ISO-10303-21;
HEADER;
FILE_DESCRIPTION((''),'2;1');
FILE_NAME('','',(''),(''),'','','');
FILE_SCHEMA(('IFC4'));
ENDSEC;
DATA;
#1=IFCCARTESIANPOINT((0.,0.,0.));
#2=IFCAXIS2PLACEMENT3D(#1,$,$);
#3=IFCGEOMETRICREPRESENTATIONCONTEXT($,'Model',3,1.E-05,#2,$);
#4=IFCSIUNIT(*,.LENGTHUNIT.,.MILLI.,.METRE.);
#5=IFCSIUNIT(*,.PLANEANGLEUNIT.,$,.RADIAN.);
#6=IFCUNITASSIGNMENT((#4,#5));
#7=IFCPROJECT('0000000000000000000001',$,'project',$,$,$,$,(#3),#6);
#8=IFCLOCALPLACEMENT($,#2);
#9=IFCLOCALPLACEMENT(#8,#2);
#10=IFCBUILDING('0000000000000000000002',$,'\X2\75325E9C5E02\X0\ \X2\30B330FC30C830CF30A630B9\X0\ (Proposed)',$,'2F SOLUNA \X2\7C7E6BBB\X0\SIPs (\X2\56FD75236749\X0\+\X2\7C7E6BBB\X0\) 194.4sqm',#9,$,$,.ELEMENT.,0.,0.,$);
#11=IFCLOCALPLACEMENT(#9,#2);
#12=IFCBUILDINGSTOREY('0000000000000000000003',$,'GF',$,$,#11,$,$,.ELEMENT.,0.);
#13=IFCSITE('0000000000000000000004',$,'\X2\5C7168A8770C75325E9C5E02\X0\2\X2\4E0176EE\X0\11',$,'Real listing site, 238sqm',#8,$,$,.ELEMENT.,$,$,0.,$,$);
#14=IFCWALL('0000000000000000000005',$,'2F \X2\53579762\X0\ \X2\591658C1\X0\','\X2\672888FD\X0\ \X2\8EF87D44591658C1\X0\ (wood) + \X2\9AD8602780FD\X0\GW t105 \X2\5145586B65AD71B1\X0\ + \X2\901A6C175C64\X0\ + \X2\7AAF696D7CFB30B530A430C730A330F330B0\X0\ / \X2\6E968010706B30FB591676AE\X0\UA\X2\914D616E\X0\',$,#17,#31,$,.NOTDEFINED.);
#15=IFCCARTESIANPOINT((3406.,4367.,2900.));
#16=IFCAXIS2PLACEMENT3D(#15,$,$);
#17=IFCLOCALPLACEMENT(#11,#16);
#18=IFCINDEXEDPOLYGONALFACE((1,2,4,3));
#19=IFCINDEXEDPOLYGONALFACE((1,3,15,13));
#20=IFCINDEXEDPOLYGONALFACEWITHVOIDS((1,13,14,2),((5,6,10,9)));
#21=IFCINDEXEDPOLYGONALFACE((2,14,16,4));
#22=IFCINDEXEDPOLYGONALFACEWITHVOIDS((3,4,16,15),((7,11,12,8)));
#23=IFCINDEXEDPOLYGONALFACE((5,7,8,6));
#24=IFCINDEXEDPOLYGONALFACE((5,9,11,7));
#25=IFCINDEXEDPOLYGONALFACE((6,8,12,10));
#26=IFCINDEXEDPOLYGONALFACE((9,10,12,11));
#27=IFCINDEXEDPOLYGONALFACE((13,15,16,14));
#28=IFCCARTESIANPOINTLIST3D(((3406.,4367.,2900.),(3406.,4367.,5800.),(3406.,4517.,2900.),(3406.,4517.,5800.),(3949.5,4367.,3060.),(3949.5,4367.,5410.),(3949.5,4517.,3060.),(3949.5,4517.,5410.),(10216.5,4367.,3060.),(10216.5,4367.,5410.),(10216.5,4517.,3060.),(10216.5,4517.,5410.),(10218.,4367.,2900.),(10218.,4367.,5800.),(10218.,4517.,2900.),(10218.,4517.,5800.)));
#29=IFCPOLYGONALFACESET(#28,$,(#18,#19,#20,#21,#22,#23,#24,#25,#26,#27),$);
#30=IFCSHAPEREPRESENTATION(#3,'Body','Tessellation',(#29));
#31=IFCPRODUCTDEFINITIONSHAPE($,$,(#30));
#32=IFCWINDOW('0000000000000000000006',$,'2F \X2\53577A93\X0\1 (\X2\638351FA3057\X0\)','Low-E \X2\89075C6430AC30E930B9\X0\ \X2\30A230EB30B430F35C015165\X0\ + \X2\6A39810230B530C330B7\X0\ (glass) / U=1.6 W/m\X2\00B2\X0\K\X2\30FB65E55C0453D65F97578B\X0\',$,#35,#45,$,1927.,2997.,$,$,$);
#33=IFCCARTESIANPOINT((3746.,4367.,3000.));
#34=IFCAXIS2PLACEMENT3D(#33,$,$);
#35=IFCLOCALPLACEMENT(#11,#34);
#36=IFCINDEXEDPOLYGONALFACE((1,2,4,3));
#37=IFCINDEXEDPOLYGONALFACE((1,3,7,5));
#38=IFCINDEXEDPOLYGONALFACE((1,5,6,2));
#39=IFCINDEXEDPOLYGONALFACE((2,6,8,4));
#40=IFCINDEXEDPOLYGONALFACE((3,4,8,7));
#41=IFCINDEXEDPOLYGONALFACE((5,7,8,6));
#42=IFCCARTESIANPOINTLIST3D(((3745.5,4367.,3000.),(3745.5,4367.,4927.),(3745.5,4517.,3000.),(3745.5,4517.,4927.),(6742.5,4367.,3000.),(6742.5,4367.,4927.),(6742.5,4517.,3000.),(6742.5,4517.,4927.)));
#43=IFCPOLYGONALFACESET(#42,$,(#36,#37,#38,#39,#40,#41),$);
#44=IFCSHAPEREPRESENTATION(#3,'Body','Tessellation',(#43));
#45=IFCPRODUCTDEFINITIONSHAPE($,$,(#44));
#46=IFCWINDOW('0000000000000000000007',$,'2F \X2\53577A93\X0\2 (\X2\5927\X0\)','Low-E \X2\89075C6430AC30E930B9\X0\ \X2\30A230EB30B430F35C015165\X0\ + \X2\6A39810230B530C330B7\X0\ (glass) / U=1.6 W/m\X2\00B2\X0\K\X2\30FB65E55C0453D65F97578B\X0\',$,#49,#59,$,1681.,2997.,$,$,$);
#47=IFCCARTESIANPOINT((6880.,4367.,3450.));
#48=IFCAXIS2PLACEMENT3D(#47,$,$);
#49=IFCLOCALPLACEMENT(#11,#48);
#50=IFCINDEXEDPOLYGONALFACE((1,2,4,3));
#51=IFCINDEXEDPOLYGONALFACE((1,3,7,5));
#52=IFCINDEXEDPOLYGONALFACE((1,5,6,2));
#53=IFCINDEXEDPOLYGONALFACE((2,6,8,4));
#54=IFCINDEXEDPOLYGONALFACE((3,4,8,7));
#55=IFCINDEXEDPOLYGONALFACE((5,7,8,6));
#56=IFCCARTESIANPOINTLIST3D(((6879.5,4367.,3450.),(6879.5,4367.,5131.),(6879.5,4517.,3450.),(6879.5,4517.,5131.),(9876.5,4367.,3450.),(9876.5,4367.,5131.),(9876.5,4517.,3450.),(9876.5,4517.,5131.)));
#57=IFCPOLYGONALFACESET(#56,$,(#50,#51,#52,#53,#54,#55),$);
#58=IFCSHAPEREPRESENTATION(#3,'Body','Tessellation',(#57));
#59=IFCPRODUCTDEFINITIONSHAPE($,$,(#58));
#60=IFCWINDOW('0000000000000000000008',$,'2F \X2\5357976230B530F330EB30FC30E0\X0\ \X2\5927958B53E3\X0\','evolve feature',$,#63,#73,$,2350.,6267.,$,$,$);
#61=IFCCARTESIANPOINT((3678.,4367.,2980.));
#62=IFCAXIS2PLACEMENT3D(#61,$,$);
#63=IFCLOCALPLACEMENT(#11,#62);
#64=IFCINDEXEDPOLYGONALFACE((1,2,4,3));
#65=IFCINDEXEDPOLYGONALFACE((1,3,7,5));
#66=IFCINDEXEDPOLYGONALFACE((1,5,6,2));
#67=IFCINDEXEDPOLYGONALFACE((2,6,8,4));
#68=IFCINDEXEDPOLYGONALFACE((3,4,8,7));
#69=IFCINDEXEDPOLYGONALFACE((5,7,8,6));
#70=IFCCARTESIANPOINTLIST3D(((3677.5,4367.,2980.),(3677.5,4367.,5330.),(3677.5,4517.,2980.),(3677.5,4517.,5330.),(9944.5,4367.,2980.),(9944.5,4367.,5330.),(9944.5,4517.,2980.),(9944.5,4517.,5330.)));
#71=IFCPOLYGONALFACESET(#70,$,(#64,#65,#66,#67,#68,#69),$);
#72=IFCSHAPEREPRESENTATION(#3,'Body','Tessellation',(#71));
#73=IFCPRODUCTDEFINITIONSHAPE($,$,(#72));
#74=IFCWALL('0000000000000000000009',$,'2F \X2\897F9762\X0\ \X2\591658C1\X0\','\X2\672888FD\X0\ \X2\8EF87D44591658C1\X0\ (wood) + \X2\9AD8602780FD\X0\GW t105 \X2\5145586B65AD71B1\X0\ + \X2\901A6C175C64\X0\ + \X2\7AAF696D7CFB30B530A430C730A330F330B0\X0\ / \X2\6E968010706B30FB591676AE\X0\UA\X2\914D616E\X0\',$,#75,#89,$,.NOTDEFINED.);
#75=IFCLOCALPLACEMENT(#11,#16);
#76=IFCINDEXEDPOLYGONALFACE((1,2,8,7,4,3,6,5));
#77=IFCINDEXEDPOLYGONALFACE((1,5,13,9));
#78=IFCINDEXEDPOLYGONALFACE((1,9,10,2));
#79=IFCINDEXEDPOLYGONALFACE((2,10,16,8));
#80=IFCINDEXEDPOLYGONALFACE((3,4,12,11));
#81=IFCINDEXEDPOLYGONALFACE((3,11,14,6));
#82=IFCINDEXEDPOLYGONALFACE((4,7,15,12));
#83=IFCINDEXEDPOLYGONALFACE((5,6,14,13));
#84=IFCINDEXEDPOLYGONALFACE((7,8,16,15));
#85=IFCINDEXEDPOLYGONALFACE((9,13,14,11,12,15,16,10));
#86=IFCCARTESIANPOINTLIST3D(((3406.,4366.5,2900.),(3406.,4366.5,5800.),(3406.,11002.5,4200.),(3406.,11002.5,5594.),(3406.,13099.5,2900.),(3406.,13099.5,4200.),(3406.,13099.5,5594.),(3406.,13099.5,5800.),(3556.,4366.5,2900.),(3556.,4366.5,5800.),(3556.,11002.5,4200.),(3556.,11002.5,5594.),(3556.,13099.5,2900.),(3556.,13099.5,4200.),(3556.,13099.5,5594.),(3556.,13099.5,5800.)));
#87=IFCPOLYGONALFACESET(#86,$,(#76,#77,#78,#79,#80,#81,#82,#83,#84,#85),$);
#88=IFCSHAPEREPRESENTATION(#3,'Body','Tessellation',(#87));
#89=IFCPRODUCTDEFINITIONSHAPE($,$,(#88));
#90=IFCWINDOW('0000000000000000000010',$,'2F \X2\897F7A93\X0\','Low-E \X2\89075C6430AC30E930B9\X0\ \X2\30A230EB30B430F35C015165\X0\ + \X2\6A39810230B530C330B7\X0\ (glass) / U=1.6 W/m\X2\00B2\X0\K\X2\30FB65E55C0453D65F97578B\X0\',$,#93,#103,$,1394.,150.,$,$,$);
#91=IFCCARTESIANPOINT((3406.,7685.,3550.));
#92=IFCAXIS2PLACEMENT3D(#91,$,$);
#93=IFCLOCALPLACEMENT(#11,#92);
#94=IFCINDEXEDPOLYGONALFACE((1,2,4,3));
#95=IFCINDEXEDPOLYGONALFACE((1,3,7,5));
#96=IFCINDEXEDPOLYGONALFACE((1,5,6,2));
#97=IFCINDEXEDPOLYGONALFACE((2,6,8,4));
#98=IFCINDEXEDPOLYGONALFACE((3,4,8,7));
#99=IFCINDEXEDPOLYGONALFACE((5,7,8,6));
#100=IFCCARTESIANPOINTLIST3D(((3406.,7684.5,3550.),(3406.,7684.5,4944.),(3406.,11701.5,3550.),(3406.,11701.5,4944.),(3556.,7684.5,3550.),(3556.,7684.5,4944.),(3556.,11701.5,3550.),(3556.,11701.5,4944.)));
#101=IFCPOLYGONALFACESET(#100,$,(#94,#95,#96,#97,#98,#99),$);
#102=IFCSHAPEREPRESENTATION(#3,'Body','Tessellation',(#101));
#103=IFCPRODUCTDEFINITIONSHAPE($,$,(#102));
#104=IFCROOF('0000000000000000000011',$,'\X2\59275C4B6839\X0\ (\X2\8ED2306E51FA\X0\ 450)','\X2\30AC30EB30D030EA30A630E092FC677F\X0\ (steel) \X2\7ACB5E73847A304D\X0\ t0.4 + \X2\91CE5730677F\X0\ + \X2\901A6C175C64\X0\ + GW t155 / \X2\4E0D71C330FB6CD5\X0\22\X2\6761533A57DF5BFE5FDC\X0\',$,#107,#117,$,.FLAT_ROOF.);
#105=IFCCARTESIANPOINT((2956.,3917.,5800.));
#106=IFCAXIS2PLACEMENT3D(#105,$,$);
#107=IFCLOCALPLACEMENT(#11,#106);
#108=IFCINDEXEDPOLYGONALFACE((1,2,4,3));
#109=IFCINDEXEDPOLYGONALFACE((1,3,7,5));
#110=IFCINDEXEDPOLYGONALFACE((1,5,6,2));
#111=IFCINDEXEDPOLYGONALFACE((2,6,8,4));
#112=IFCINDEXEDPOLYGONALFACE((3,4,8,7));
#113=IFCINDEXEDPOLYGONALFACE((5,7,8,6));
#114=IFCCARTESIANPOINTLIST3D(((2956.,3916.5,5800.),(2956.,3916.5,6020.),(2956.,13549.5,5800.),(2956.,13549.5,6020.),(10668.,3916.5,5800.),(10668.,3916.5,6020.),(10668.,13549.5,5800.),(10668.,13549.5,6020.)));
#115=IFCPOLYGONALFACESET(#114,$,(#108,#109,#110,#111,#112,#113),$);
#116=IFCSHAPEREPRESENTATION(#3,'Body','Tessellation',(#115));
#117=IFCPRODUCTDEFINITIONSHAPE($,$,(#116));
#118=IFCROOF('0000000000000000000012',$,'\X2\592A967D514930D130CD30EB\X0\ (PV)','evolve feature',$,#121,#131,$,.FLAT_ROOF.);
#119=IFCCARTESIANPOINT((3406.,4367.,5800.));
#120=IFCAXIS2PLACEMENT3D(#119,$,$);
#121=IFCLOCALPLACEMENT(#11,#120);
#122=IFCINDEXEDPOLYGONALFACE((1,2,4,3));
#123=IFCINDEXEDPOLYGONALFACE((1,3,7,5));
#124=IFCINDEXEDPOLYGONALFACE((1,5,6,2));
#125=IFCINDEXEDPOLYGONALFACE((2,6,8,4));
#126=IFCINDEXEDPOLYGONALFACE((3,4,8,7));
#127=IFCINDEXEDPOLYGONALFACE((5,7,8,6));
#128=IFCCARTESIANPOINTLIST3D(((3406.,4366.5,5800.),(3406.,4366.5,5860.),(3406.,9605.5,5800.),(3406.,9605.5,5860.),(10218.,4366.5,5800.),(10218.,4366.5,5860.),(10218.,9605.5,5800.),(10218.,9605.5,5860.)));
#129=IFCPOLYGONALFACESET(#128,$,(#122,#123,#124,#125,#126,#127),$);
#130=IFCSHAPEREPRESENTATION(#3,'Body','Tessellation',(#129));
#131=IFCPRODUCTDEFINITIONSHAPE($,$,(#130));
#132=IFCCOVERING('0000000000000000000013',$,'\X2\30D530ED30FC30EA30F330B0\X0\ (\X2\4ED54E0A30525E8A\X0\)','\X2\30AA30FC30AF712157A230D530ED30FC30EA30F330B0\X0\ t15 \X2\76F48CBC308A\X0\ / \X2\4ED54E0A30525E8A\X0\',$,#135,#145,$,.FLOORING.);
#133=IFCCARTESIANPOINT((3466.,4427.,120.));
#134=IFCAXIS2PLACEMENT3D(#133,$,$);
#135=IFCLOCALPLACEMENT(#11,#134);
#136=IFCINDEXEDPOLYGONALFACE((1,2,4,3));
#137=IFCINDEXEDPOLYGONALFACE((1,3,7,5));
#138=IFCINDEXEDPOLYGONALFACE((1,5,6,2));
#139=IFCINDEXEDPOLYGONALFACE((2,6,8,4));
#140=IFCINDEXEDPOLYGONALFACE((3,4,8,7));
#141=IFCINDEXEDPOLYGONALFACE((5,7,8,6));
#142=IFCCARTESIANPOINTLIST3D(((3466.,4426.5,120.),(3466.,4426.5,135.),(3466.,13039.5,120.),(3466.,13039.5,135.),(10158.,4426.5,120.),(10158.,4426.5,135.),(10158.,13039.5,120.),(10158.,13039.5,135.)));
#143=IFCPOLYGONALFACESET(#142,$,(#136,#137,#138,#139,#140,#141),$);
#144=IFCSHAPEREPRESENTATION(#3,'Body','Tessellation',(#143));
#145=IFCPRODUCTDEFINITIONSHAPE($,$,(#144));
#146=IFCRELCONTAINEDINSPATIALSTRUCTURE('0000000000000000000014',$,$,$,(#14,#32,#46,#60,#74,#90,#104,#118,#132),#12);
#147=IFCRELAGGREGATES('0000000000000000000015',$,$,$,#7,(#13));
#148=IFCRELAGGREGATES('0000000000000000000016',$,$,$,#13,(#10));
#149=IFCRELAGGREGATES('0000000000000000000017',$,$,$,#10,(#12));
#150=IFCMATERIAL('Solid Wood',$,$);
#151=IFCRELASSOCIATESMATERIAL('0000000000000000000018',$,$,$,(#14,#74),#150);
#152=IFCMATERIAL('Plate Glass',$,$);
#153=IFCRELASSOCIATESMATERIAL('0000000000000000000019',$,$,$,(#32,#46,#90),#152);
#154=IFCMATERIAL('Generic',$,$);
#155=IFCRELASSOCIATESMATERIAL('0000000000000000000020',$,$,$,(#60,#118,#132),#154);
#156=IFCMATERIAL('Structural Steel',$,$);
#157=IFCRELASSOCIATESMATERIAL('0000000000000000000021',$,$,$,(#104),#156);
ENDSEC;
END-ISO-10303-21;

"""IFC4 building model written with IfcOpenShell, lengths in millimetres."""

from ifc_helpers import new_model, si_unit, frame, frame_2d, origin, place, context, project, spatial, rectangle, extrude, material, element, fill, save


model = new_model("IFC4")

# Units and contexts
model_context = context("Model", 3, precision=1e-05, world=origin())
ifc_project = project(units=[si_unit("LENGTHUNIT", "METRE", prefix="MILLI"), si_unit("PLANEANGLEUNIT", "RADIAN")], contexts=[model_context])

# Site, building, storey
site_placement = place(None, origin())
site = spatial("IfcSite", under=ifc_project, at=site_placement, Name="山梨県甲府市2丁目11", ObjectType="Real listing site, 238sqm", CompositionType="ELEMENT", RefElevation=0.0)
building_placement = place(site_placement, origin())
building = spatial("IfcBuilding", under=site, at=building_placement, Name="甲府市 コートハウス (Proposed)", ObjectType="2F SOLUNA 籾殻SIPs (国産杉+籾殻) 194.4sqm", CompositionType="ELEMENT", ElevationOfRefHeight=0.0, ElevationOfTerrain=0.0)
storey_placement = place(building_placement, origin())
storey = spatial("IfcBuildingStorey", under=building, at=storey_placement, Name="GF", CompositionType="ELEMENT", Elevation=0.0)

# Shared definitions
ifc_material_1 = material(Name="Solid Wood")

# Shared definitions
ifc_material_2 = material(Name="Plate Glass")
ifc_material_3 = material(Name="Generic")

# Wall, openings, windows
wall_1_placement = place(storey_placement, frame((3406.0, 4367.0, 2900.0)))
wall_1 = element("IfcWall", 1, at=wall_1_placement, inside=storey, material=ifc_material_1, Name="2F 南面 外壁", Description="木製 軸組外壁 (wood) + 高性能GW t105 充填断熱 + 通気層 + 窯業系サイディング / 準耐火・外皮UA配慮", PredefinedType="NOTDEFINED", context=model_context, shape_type="SweptSolid", body=[
    extrude(rectangle(XDim=6812.0, YDim=150.0, at=frame_2d((3406.0, 75.0))), frame((3406.0, 4367.0, 2900.0)), (0.0, 0.0, 1.0), 2900.0),
])
opening_1_placement = place(storey_placement, frame((3746.0, 4367.0, 3000.0)))
opening_1 = element("IfcOpeningElement", 2, at=opening_1_placement, cuts=wall_1, PredefinedType="NOTDEFINED", context=model_context, shape_type="SweptSolid", body=[
    extrude(rectangle(XDim=2997.0, YDim=150.0, at=frame_2d((1498.0, 75.0))), frame((3746.0, 4367.0, 3000.0)), (0.0, 0.0, 1.0), 1927.0),
])
opening_2_placement = place(storey_placement, frame((6880.0, 4367.0, 3450.0)))
opening_2 = element("IfcOpeningElement", 3, at=opening_2_placement, cuts=wall_1, PredefinedType="NOTDEFINED", context=model_context, shape_type="SweptSolid", body=[
    extrude(rectangle(XDim=2997.0, YDim=150.0, at=frame_2d((1498.0, 75.0))), frame((6880.0, 4367.0, 3450.0)), (0.0, 0.0, 1.0), 1681.0),
])
opening_3_placement = place(storey_placement, frame((3678.0, 4367.0, 2980.0)))
opening_3 = element("IfcOpeningElement", 4, at=opening_3_placement, cuts=wall_1, PredefinedType="NOTDEFINED", context=model_context, shape_type="SweptSolid", body=[
    extrude(rectangle(XDim=6267.0, YDim=150.0, at=frame_2d((3133.0, 75.0))), frame((3678.0, 4367.0, 2980.0)), (0.0, 0.0, 1.0), 2350.0),
])
window_1_placement = place(storey_placement, frame((3746.0, 4367.0, 3000.0)))
window_1 = element("IfcWindow", 5, at=window_1_placement, inside=storey, material=ifc_material_2, Name="2F 南窓1 (掃出し)", Description="Low-E 複層ガラス アルゴン封入 + 樹脂サッシ (glass) / U=1.6 W/m²K・日射取得型", OverallHeight=1927.0, OverallWidth=2997.0, context=model_context, shape_type="SweptSolid", body=[
    extrude(rectangle(XDim=2997.0, YDim=150.0, at=frame_2d((1498.0, 75.0))), frame((3746.0, 4367.0, 3000.0)), (0.0, 0.0, 1.0), 1927.0),
])
fill(opening_1, window_1)
window_2_placement = place(storey_placement, frame((6880.0, 4367.0, 3450.0)))
window_2 = element("IfcWindow", 6, at=window_2_placement, inside=storey, material=ifc_material_2, Name="2F 南窓2 (大)", Description="Low-E 複層ガラス アルゴン封入 + 樹脂サッシ (glass) / U=1.6 W/m²K・日射取得型", OverallHeight=1681.0, OverallWidth=2997.0, context=model_context, shape_type="SweptSolid", body=[
    extrude(rectangle(XDim=2997.0, YDim=150.0, at=frame_2d((1498.0, 75.0))), frame((6880.0, 4367.0, 3450.0)), (0.0, 0.0, 1.0), 1681.0),
])
fill(opening_2, window_2)
window_3_placement = place(storey_placement, frame((3678.0, 4367.0, 2980.0)))
window_3 = element("IfcWindow", 7, at=window_3_placement, inside=storey, material=ifc_material_3, Name="2F 南面サンルーム 大開口", Description="evolve feature", OverallHeight=2350.0, OverallWidth=6267.0, context=model_context, shape_type="SweptSolid", body=[
    extrude(rectangle(XDim=6267.0, YDim=150.0, at=frame_2d((3133.0, 75.0))), frame((3678.0, 4367.0, 2980.0)), (0.0, 0.0, 1.0), 2350.0),
])
fill(opening_3, window_3)

# Wall, opening, window
wall_2_placement = place(storey_placement, frame((3406.0, 4367.0, 2900.0)))
wall_2 = element("IfcWall", 8, at=wall_2_placement, inside=storey, material=ifc_material_1, Name="2F 西面 外壁", Description="木製 軸組外壁 (wood) + 高性能GW t105 充填断熱 + 通気層 + 窯業系サイディング / 準耐火・外皮UA配慮", PredefinedType="NOTDEFINED", context=model_context, shape_type="SweptSolid", body=[
    extrude(rectangle(XDim=150.0, YDim=8733.0, at=frame_2d((75.0, 4366.0))), frame((3406.0, 4367.0, 2900.0)), (0.0, 0.0, 1.0), 2900.0),
])
opening_4_placement = place(storey_placement, frame((3406.0, 7685.0, 3550.0)))
opening_4 = element("IfcOpeningElement", 9, at=opening_4_placement, cuts=wall_2, PredefinedType="NOTDEFINED", context=model_context, shape_type="SweptSolid", body=[
    extrude(rectangle(XDim=150.0, YDim=4017.0, at=frame_2d((75.0, 2008.0))), frame((3406.0, 7685.0, 3550.0)), (0.0, 0.0, 1.0), 1394.0),
])
window_4_placement = place(storey_placement, frame((3406.0, 7685.0, 3550.0)))
window_4 = element("IfcWindow", 10, at=window_4_placement, inside=storey, material=ifc_material_2, Name="2F 西窓", Description="Low-E 複層ガラス アルゴン封入 + 樹脂サッシ (glass) / U=1.6 W/m²K・日射取得型", OverallHeight=1394.0, OverallWidth=150.0, context=model_context, shape_type="SweptSolid", body=[
    extrude(rectangle(XDim=150.0, YDim=4017.0, at=frame_2d((75.0, 2008.0))), frame((3406.0, 7685.0, 3550.0)), (0.0, 0.0, 1.0), 1394.0),
])
fill(opening_4, window_4)

# Roofs
ifc_material_4 = material(Name="Structural Steel")
roof_1_placement = place(storey_placement, frame((2956.0, 3917.0, 5800.0)))
element("IfcRoof", 11, at=roof_1_placement, inside=storey, material=ifc_material_4, Name="大屋根 (軒の出 450)", Description="ガルバリウム鋼板 (steel) 立平葺き t0.4 + 野地板 + 通気層 + GW t155 / 不燃・法22条区域対応", PredefinedType="FLAT_ROOF", context=model_context, shape_type="SweptSolid", body=[
    extrude(rectangle(XDim=7712.0, YDim=9633.0, at=frame_2d((3856.0, 4816.0))), frame((2956.0, 3917.0, 5800.0)), (0.0, 0.0, 1.0), 220.0),
])
roof_2_placement = place(storey_placement, frame((3406.0, 4367.0, 5800.0)))
element("IfcRoof", 12, at=roof_2_placement, inside=storey, material=ifc_material_3, Name="太陽光パネル (PV)", Description="evolve feature", PredefinedType="FLAT_ROOF", context=model_context, shape_type="SweptSolid", body=[
    extrude(rectangle(XDim=6812.0, YDim=5239.0, at=frame_2d((3406.0, 2619.0))), frame((3406.0, 4367.0, 5800.0)), (0.0, 0.0, 1.0), 60.0),
])

# Covering
covering_placement = place(storey_placement, frame((3466.0, 4427.0, 120.0)))
element("IfcCovering", 13, at=covering_placement, inside=storey, material=ifc_material_3, Name="フローリング (仕上げ床)", Description="オーク無垢フローリング t15 直貼り / 仕上げ床", PredefinedType="FLOORING", context=model_context, shape_type="SweptSolid", body=[
    extrude(rectangle(XDim=6692.0, YDim=8613.0, at=frame_2d((3346.0, 4306.0))), frame((3466.0, 4427.0, 120.0)), (0.0, 0.0, 1.0), 15.0),
])

save(model, "model.ifc")
